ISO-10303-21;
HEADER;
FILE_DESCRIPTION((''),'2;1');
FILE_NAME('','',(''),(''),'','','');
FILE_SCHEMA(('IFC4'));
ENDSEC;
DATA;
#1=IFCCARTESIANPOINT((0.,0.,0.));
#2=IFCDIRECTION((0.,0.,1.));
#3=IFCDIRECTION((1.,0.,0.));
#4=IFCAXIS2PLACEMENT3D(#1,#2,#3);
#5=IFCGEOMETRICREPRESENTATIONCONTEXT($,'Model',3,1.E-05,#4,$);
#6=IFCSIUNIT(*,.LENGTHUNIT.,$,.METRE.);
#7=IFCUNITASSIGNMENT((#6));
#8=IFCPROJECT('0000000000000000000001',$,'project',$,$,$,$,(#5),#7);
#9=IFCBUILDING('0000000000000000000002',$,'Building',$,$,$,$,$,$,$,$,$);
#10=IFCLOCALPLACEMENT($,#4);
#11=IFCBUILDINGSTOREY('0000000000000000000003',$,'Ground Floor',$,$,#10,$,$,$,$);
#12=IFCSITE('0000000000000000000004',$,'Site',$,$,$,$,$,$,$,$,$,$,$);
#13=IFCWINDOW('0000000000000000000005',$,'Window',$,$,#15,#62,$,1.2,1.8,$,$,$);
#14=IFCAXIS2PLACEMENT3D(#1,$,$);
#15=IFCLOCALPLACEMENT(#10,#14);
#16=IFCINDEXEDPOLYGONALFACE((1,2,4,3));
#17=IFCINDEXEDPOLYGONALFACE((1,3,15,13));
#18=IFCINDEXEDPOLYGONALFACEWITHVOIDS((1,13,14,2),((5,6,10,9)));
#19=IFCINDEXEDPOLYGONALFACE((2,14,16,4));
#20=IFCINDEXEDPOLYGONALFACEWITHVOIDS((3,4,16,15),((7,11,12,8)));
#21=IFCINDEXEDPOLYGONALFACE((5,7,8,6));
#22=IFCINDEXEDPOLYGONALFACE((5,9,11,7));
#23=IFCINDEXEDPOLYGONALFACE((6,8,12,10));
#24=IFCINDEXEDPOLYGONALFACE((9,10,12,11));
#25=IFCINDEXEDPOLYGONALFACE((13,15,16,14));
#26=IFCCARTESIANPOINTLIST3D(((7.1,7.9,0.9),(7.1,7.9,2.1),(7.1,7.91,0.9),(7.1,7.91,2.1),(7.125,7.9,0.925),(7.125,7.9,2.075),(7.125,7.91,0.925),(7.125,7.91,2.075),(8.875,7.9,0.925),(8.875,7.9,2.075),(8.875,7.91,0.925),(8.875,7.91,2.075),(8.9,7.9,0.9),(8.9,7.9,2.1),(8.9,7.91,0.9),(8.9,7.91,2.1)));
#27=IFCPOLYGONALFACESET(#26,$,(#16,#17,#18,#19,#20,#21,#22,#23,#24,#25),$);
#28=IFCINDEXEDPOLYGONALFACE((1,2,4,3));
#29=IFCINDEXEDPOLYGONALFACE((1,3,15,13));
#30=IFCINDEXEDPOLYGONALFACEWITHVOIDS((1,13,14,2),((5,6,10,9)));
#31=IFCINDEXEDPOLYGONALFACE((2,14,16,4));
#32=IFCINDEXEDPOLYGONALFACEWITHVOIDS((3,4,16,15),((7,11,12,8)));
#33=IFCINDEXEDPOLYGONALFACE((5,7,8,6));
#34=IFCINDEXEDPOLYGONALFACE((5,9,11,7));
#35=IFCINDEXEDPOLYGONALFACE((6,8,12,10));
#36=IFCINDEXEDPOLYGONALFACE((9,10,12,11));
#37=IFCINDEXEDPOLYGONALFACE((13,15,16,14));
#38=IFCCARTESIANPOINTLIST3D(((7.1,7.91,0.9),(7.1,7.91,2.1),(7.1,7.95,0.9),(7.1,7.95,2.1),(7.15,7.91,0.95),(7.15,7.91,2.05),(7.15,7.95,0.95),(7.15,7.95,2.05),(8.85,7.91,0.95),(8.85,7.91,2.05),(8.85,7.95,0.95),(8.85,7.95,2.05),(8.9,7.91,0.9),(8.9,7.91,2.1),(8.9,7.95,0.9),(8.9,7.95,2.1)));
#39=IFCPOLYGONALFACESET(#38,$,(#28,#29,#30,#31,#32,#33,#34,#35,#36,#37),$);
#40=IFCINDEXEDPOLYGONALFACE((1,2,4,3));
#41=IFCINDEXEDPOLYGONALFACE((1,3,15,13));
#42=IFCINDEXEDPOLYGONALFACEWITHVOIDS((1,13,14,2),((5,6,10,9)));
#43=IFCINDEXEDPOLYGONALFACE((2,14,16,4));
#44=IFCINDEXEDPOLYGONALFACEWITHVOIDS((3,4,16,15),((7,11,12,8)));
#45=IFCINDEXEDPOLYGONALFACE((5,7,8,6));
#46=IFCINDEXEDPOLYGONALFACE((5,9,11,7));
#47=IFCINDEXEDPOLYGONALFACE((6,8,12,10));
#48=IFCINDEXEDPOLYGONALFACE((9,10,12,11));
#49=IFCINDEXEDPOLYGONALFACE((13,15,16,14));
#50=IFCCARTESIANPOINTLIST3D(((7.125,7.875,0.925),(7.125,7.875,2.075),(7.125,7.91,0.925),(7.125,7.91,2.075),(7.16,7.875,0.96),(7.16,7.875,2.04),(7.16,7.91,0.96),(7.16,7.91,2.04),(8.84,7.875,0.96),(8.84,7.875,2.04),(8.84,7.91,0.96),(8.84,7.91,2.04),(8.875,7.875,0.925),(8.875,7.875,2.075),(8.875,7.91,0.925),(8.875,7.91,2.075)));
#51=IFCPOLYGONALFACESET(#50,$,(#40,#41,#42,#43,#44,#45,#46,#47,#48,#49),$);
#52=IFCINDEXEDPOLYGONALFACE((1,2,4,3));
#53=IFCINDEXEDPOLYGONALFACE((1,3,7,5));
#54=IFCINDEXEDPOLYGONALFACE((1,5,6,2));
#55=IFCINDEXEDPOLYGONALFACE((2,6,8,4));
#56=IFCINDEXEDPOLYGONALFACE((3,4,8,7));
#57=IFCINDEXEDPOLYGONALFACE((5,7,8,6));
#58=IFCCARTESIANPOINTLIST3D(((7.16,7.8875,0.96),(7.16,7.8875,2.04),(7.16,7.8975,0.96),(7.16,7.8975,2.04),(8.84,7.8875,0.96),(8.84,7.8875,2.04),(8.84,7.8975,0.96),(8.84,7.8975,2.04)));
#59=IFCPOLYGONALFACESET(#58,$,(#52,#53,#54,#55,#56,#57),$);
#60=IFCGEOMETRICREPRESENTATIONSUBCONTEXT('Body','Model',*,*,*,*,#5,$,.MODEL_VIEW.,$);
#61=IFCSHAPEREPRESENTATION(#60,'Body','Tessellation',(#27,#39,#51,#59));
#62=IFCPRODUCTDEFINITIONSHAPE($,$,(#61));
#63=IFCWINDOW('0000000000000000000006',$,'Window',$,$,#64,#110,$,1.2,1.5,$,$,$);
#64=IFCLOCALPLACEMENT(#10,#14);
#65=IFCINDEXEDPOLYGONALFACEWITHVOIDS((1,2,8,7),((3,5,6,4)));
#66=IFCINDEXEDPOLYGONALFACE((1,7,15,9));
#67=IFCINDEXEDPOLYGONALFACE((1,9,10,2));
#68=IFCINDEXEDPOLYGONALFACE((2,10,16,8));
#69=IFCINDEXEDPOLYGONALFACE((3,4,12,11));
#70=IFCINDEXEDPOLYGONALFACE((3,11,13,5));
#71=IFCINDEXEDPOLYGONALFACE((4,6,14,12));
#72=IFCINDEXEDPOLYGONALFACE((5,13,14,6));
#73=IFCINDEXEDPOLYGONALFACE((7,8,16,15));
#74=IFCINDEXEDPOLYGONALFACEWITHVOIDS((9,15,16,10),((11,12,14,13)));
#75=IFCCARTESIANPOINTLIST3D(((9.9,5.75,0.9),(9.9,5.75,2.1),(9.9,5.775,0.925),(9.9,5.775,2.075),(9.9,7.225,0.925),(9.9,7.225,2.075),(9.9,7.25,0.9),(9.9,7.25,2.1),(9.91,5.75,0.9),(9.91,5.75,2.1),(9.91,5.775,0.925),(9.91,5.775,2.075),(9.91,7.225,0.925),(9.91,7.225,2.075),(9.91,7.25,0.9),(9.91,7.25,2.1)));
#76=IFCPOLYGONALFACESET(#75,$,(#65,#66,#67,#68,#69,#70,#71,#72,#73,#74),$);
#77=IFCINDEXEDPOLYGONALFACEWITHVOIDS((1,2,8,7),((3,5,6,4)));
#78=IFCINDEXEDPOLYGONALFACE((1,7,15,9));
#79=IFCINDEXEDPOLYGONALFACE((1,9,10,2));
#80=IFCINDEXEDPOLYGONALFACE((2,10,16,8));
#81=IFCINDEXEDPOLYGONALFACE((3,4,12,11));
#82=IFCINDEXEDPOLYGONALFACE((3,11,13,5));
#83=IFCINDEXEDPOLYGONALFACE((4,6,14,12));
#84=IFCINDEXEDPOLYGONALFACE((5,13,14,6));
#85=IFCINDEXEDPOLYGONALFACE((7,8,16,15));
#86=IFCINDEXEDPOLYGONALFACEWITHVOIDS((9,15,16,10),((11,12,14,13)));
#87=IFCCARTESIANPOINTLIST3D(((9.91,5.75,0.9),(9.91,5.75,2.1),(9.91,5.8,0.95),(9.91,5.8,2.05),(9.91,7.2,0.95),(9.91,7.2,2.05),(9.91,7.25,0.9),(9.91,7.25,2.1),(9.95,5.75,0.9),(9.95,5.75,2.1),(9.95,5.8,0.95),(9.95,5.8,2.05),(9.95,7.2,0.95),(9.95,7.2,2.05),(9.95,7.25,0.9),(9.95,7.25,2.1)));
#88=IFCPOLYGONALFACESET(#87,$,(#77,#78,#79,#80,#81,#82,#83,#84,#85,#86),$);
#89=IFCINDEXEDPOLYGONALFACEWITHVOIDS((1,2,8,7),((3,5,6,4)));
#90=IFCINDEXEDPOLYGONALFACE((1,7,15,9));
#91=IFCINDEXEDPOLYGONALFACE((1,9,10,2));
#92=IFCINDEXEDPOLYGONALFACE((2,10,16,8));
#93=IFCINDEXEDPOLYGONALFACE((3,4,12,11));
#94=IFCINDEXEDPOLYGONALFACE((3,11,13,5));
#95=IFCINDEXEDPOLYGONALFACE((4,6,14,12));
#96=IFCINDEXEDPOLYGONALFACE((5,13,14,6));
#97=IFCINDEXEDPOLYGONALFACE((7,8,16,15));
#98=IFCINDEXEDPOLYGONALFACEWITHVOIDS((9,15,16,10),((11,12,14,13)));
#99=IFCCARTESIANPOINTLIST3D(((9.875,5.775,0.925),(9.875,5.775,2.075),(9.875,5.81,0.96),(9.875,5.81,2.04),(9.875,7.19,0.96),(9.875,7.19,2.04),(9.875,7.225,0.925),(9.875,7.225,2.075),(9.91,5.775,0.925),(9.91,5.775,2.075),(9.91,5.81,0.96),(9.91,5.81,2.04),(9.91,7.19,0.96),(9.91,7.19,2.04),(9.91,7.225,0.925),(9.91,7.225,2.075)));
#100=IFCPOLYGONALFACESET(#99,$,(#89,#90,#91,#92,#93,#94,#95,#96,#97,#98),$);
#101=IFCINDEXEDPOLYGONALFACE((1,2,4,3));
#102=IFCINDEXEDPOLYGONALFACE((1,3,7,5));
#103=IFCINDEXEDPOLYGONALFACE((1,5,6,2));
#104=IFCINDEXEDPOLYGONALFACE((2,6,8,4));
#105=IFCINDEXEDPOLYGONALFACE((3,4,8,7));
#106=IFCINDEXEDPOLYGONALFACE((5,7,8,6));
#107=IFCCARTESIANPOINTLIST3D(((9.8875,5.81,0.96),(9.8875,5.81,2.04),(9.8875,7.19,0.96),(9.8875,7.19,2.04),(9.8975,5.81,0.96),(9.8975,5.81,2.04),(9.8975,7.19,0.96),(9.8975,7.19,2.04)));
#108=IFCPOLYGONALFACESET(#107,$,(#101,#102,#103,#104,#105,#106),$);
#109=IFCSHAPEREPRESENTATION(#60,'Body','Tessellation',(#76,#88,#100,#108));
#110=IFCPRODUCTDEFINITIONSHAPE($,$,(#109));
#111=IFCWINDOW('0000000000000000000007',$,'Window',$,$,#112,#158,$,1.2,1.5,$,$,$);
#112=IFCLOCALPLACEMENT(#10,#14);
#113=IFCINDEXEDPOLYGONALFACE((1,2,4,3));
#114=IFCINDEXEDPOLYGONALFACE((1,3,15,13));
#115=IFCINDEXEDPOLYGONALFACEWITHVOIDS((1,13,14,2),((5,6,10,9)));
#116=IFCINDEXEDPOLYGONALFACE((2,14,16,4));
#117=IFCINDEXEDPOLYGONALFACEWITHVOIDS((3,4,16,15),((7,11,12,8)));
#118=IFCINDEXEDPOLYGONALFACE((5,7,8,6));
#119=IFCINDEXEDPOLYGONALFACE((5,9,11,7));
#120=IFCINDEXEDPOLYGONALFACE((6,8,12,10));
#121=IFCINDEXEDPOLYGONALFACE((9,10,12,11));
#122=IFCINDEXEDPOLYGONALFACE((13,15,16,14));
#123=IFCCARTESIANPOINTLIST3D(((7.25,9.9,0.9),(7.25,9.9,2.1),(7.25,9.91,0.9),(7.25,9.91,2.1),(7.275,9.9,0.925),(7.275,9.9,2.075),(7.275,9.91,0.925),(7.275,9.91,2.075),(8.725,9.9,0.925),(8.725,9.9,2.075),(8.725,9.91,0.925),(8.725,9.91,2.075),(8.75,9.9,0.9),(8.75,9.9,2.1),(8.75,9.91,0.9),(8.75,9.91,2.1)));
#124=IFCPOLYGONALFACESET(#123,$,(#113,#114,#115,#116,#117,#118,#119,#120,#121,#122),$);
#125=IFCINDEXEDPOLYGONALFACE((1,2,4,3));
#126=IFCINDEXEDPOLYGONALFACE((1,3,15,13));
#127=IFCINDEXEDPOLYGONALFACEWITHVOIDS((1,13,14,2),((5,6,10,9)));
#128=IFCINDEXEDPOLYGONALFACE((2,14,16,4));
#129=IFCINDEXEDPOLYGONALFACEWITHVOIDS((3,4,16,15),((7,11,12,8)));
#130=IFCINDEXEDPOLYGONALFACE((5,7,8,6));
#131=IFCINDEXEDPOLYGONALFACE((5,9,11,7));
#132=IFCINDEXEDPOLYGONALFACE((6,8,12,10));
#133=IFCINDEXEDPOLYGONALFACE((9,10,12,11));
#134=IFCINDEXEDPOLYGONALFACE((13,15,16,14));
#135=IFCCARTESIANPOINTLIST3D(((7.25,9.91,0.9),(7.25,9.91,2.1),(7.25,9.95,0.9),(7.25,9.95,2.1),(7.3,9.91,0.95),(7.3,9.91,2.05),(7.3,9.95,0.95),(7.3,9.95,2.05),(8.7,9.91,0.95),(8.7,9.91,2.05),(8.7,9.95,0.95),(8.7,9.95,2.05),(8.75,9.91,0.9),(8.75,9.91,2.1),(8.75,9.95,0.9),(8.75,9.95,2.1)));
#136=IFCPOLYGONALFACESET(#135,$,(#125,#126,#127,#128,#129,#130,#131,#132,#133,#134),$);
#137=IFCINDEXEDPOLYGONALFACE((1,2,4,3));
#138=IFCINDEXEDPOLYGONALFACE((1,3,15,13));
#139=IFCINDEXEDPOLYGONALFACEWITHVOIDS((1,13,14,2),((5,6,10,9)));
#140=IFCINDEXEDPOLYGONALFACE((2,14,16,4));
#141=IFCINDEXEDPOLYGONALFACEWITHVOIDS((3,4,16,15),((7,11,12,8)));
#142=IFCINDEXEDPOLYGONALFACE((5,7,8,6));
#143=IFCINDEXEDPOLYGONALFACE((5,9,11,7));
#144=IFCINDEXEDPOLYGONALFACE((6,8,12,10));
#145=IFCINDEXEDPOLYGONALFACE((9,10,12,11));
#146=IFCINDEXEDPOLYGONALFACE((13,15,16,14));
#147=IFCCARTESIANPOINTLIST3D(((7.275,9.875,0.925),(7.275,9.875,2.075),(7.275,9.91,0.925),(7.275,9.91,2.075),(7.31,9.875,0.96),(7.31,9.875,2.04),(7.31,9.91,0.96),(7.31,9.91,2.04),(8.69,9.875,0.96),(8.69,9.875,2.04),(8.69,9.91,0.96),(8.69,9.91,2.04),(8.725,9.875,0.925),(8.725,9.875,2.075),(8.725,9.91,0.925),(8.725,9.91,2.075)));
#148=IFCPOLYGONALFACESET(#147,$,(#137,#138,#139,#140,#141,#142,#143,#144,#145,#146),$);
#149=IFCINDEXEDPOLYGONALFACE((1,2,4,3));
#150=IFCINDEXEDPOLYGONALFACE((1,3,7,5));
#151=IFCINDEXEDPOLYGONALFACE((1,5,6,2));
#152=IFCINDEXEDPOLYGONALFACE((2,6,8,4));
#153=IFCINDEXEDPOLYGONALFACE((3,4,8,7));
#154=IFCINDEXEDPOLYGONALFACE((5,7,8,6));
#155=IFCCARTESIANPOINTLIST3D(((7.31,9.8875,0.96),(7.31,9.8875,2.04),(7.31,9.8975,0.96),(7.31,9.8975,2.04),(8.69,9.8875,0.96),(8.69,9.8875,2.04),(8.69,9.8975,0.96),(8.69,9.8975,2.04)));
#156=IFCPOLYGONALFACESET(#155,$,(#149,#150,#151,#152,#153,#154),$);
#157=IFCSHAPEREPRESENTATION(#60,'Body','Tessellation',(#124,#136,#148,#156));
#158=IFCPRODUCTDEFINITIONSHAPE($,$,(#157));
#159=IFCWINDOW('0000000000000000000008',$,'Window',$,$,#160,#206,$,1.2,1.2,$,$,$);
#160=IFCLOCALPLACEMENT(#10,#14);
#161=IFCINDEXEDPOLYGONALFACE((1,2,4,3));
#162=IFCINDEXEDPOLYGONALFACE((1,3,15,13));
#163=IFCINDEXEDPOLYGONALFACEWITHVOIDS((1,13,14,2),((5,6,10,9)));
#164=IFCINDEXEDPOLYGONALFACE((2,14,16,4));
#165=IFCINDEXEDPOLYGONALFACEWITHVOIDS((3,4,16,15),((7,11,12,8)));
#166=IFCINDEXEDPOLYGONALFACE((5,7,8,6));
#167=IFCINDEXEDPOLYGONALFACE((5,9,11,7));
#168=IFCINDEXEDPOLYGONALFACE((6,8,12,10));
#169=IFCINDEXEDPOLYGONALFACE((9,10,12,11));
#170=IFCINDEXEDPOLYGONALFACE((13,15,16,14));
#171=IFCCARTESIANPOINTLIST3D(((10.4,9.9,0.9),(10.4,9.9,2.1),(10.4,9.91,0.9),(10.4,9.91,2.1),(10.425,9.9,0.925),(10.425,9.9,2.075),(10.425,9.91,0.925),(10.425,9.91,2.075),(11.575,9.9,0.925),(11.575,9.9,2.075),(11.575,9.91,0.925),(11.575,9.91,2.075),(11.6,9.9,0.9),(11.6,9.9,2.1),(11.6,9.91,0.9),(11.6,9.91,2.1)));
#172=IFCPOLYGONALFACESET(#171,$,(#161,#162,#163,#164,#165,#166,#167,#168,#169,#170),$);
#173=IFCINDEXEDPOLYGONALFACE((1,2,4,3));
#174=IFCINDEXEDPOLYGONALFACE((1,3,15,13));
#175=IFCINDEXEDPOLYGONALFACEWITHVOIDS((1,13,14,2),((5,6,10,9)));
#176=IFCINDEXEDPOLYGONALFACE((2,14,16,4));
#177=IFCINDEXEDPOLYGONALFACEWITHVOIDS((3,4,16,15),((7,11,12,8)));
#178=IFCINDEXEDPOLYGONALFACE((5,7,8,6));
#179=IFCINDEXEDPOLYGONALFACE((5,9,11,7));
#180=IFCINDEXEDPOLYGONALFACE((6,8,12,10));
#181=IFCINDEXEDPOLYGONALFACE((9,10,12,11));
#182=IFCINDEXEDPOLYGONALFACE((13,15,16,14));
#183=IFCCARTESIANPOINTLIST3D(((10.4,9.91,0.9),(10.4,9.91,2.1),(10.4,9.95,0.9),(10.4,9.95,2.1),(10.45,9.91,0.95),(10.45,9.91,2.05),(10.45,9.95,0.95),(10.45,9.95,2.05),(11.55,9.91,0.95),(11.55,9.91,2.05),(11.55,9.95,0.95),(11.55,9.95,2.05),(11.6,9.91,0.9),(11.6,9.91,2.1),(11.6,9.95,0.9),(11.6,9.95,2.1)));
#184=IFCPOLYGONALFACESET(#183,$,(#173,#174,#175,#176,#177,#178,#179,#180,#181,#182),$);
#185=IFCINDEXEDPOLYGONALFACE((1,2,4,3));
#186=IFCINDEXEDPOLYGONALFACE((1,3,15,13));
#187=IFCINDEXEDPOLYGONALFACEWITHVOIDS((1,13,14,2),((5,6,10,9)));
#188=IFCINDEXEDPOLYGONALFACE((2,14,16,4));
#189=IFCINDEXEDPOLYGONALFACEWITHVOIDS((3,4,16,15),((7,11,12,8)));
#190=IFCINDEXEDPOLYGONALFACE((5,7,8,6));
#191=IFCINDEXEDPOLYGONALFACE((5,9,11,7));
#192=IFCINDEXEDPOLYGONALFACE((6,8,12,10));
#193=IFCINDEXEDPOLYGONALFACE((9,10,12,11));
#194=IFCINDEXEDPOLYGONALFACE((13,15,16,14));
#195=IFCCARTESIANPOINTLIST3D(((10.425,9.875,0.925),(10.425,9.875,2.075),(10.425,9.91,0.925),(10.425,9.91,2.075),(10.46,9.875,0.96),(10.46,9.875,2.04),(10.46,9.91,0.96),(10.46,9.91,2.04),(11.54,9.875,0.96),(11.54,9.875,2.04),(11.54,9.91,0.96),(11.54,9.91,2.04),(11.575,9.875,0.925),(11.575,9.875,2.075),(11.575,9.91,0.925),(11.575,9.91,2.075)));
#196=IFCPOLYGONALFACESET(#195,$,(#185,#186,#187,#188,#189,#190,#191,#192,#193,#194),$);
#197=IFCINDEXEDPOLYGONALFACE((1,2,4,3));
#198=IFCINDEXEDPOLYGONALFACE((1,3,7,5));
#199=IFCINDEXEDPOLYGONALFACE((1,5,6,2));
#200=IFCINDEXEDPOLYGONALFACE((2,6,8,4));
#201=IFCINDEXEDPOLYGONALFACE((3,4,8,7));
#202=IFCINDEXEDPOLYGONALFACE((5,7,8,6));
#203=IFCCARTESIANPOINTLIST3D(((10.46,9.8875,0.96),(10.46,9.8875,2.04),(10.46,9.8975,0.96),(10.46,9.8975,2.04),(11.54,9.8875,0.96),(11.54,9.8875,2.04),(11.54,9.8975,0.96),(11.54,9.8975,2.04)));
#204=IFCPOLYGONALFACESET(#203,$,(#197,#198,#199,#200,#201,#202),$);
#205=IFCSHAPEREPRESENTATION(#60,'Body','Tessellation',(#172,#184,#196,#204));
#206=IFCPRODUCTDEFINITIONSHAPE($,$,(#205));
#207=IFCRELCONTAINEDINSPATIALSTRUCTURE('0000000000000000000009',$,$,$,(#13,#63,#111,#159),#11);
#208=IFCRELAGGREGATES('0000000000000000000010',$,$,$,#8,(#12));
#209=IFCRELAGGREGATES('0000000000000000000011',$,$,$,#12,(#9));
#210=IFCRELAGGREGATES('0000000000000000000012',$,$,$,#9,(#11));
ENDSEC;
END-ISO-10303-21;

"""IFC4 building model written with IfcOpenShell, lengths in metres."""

from ifc_helpers import new_model, si_unit, frame, origin_with_axes, place, context, subcontext, project, spatial, line, indexed_curve, outline, extrude, element, save


model = new_model("IFC4")

# Units and contexts
model_context = context("Model", 3, precision=1e-05, world=origin_with_axes())
body_context = subcontext(model_context, "Body", "Model", "MODEL_VIEW")
ifc_project = project(units=[si_unit("LENGTHUNIT", "METRE")], contexts=[model_context])

# Site, building, storey
site = spatial("IfcSite", under=ifc_project, Name="Site")
building = spatial("IfcBuilding", under=site, Name="Building")
storey_placement = place(None, origin_with_axes())
storey = spatial("IfcBuildingStorey", under=building, at=storey_placement, Name="Ground Floor")

# Windows
window_1_placement = place(storey_placement, frame((8.9, 8.0, 0.9), z_axis=(0.0, 0.0, 1.0), x_axis=(-1.0, 0.0, 0.0)))
element("IfcWindow", 1, at=window_1_placement, inside=storey, Name="Window", OverallHeight=1.2, OverallWidth=1.8, context=body_context, shape_type="SweptSolid", body=[
    extrude(outline(indexed_curve([(0.0, 0.0), (1.8, 0.0), (1.8, 1.2), (0.0, 1.2)], segments=[line(1, 2, 3, 4, 1)]), holes=[indexed_curve([(0.025, 0.025), (1.775, 0.025), (1.775, 1.175), (0.025, 1.175)], segments=[line(1, 2, 3, 4, 1)])]), frame((0.0, 0.09, 0.0), z_axis=(0.0, -1.0, 0.0), x_axis=(1.0, 0.0, 0.0)), (0.0, 0.0, -1.0), 0.01),
    extrude(outline(indexed_curve([(0.0, 0.0), (1.8, 0.0), (1.8, 1.2), (0.0, 1.2)], segments=[line(1, 2, 3, 4, 1)]), holes=[indexed_curve([(0.05, 0.05), (1.75, 0.05), (1.75, 1.15), (0.05, 1.15)], segments=[line(1, 2, 3, 4, 1)])]), frame((0.0, 0.05, 0.0), z_axis=(0.0, -1.0, 0.0), x_axis=(1.0, 0.0, 0.0)), (0.0, 0.0, -1.0), 0.04),
    extrude(outline(indexed_curve([(0.0, 0.0), (1.75, 0.0), (1.75, 1.15), (0.0, 1.15)], segments=[line(1, 2, 3, 4, 1)]), holes=[indexed_curve([(0.035, 0.035), (1.715, 0.035), (1.715, 1.115), (0.035, 1.115)], segments=[line(1, 2, 3, 4, 1)])]), frame((0.025, 0.09, 0.025), z_axis=(0.0, -1.0, 0.0), x_axis=(1.0, 0.0, 0.0)), (0.0, 0.0, -1.0), 0.035),
    extrude(outline(indexed_curve([(0.035, 0.035), (1.715, 0.035), (1.715, 1.115), (0.035, 1.115)], segments=[line(1, 2, 3, 4, 1)])), frame((0.025, 0.1025, 0.025), z_axis=(0.0, -1.0, 0.0), x_axis=(1.0, 0.0, 0.0)), (0.0, 0.0, -1.0), 0.01),
])
for number, where, z_axis, x_axis, name in (
    (2, (10.0, 5.75, 0.9), (0.0, 0.0, 1.0), (0.0, 1.0, 0.0), "Window"),
    (3, (8.75, 10.0, 0.9), (0.0, 0.0, 1.0), (-1.0, 0.0, 0.0), "Window"),
):
    element("IfcWindow", number, at=place(storey_placement, frame(where, z_axis=z_axis, x_axis=x_axis)), inside=storey, Name=name, OverallHeight=1.2, OverallWidth=1.5, context=body_context, shape_type="SweptSolid", body=[
        extrude(outline(indexed_curve([(0.0, 0.0), (1.5, 0.0), (1.5, 1.2), (0.0, 1.2)], segments=[line(1, 2, 3, 4, 1)]), holes=[indexed_curve([(0.025, 0.025), (1.475, 0.025), (1.475, 1.175), (0.025, 1.175)], segments=[line(1, 2, 3, 4, 1)])]), frame((0.0, 0.09, 0.0), z_axis=(0.0, -1.0, 0.0), x_axis=(1.0, 0.0, 0.0)), (0.0, 0.0, -1.0), 0.01),
        extrude(outline(indexed_curve([(0.0, 0.0), (1.5, 0.0), (1.5, 1.2), (0.0, 1.2)], segments=[line(1, 2, 3, 4, 1)]), holes=[indexed_curve([(0.05, 0.05), (1.45, 0.05), (1.45, 1.15), (0.05, 1.15)], segments=[line(1, 2, 3, 4, 1)])]), frame((0.0, 0.05, 0.0), z_axis=(0.0, -1.0, 0.0), x_axis=(1.0, 0.0, 0.0)), (0.0, 0.0, -1.0), 0.04),
        extrude(outline(indexed_curve([(0.0, 0.0), (1.45, 0.0), (1.45, 1.15), (0.0, 1.15)], segments=[line(1, 2, 3, 4, 1)]), holes=[indexed_curve([(0.035, 0.035), (1.415, 0.035), (1.415, 1.115), (0.035, 1.115)], segments=[line(1, 2, 3, 4, 1)])]), frame((0.025, 0.09, 0.025), z_axis=(0.0, -1.0, 0.0), x_axis=(1.0, 0.0, 0.0)), (0.0, 0.0, -1.0), 0.035),
        extrude(outline(indexed_curve([(0.035, 0.035), (1.415, 0.035), (1.415, 1.115), (0.035, 1.115)], segments=[line(1, 2, 3, 4, 1)])), frame((0.025, 0.1025, 0.025), z_axis=(0.0, -1.0, 0.0), x_axis=(1.0, 0.0, 0.0)), (0.0, 0.0, -1.0), 0.01),
    ])
window_2_placement = place(storey_placement, frame((11.6, 10.0, 0.9), z_axis=(0.0, 0.0, 1.0), x_axis=(-1.0, 0.0, 0.0)))
element("IfcWindow", 4, at=window_2_placement, inside=storey, Name="Window", OverallHeight=1.2, OverallWidth=1.2, context=body_context, shape_type="SweptSolid", body=[
    extrude(outline(indexed_curve([(0.0, 0.0), (1.2, 0.0), (1.2, 1.2), (0.0, 1.2)], segments=[line(1, 2, 3, 4, 1)]), holes=[indexed_curve([(0.025, 0.025), (1.175, 0.025), (1.175, 1.175), (0.025, 1.175)], segments=[line(1, 2, 3, 4, 1)])]), frame((0.0, 0.09, 0.0), z_axis=(0.0, -1.0, 0.0), x_axis=(1.0, 0.0, 0.0)), (0.0, 0.0, -1.0), 0.01),
    extrude(outline(indexed_curve([(0.0, 0.0), (1.2, 0.0), (1.2, 1.2), (0.0, 1.2)], segments=[line(1, 2, 3, 4, 1)]), holes=[indexed_curve([(0.05, 0.05), (1.15, 0.05), (1.15, 1.15), (0.05, 1.15)], segments=[line(1, 2, 3, 4, 1)])]), frame((0.0, 0.05, 0.0), z_axis=(0.0, -1.0, 0.0), x_axis=(1.0, 0.0, 0.0)), (0.0, 0.0, -1.0), 0.04),
    extrude(outline(indexed_curve([(0.0, 0.0), (1.15, 0.0), (1.15, 1.15), (0.0, 1.15)], segments=[line(1, 2, 3, 4, 1)]), holes=[indexed_curve([(0.035, 0.035), (1.115, 0.035), (1.115, 1.115), (0.035, 1.115)], segments=[line(1, 2, 3, 4, 1)])]), frame((0.025, 0.09, 0.025), z_axis=(0.0, -1.0, 0.0), x_axis=(1.0, 0.0, 0.0)), (0.0, 0.0, -1.0), 0.035),
    extrude(outline(indexed_curve([(0.035, 0.035), (1.115, 0.035), (1.115, 1.115), (0.035, 1.115)], segments=[line(1, 2, 3, 4, 1)])), frame((0.025, 0.1025, 0.025), z_axis=(0.0, -1.0, 0.0), x_axis=(1.0, 0.0, 0.0)), (0.0, 0.0, -1.0), 0.01),
])

save(model, "model.ifc")
